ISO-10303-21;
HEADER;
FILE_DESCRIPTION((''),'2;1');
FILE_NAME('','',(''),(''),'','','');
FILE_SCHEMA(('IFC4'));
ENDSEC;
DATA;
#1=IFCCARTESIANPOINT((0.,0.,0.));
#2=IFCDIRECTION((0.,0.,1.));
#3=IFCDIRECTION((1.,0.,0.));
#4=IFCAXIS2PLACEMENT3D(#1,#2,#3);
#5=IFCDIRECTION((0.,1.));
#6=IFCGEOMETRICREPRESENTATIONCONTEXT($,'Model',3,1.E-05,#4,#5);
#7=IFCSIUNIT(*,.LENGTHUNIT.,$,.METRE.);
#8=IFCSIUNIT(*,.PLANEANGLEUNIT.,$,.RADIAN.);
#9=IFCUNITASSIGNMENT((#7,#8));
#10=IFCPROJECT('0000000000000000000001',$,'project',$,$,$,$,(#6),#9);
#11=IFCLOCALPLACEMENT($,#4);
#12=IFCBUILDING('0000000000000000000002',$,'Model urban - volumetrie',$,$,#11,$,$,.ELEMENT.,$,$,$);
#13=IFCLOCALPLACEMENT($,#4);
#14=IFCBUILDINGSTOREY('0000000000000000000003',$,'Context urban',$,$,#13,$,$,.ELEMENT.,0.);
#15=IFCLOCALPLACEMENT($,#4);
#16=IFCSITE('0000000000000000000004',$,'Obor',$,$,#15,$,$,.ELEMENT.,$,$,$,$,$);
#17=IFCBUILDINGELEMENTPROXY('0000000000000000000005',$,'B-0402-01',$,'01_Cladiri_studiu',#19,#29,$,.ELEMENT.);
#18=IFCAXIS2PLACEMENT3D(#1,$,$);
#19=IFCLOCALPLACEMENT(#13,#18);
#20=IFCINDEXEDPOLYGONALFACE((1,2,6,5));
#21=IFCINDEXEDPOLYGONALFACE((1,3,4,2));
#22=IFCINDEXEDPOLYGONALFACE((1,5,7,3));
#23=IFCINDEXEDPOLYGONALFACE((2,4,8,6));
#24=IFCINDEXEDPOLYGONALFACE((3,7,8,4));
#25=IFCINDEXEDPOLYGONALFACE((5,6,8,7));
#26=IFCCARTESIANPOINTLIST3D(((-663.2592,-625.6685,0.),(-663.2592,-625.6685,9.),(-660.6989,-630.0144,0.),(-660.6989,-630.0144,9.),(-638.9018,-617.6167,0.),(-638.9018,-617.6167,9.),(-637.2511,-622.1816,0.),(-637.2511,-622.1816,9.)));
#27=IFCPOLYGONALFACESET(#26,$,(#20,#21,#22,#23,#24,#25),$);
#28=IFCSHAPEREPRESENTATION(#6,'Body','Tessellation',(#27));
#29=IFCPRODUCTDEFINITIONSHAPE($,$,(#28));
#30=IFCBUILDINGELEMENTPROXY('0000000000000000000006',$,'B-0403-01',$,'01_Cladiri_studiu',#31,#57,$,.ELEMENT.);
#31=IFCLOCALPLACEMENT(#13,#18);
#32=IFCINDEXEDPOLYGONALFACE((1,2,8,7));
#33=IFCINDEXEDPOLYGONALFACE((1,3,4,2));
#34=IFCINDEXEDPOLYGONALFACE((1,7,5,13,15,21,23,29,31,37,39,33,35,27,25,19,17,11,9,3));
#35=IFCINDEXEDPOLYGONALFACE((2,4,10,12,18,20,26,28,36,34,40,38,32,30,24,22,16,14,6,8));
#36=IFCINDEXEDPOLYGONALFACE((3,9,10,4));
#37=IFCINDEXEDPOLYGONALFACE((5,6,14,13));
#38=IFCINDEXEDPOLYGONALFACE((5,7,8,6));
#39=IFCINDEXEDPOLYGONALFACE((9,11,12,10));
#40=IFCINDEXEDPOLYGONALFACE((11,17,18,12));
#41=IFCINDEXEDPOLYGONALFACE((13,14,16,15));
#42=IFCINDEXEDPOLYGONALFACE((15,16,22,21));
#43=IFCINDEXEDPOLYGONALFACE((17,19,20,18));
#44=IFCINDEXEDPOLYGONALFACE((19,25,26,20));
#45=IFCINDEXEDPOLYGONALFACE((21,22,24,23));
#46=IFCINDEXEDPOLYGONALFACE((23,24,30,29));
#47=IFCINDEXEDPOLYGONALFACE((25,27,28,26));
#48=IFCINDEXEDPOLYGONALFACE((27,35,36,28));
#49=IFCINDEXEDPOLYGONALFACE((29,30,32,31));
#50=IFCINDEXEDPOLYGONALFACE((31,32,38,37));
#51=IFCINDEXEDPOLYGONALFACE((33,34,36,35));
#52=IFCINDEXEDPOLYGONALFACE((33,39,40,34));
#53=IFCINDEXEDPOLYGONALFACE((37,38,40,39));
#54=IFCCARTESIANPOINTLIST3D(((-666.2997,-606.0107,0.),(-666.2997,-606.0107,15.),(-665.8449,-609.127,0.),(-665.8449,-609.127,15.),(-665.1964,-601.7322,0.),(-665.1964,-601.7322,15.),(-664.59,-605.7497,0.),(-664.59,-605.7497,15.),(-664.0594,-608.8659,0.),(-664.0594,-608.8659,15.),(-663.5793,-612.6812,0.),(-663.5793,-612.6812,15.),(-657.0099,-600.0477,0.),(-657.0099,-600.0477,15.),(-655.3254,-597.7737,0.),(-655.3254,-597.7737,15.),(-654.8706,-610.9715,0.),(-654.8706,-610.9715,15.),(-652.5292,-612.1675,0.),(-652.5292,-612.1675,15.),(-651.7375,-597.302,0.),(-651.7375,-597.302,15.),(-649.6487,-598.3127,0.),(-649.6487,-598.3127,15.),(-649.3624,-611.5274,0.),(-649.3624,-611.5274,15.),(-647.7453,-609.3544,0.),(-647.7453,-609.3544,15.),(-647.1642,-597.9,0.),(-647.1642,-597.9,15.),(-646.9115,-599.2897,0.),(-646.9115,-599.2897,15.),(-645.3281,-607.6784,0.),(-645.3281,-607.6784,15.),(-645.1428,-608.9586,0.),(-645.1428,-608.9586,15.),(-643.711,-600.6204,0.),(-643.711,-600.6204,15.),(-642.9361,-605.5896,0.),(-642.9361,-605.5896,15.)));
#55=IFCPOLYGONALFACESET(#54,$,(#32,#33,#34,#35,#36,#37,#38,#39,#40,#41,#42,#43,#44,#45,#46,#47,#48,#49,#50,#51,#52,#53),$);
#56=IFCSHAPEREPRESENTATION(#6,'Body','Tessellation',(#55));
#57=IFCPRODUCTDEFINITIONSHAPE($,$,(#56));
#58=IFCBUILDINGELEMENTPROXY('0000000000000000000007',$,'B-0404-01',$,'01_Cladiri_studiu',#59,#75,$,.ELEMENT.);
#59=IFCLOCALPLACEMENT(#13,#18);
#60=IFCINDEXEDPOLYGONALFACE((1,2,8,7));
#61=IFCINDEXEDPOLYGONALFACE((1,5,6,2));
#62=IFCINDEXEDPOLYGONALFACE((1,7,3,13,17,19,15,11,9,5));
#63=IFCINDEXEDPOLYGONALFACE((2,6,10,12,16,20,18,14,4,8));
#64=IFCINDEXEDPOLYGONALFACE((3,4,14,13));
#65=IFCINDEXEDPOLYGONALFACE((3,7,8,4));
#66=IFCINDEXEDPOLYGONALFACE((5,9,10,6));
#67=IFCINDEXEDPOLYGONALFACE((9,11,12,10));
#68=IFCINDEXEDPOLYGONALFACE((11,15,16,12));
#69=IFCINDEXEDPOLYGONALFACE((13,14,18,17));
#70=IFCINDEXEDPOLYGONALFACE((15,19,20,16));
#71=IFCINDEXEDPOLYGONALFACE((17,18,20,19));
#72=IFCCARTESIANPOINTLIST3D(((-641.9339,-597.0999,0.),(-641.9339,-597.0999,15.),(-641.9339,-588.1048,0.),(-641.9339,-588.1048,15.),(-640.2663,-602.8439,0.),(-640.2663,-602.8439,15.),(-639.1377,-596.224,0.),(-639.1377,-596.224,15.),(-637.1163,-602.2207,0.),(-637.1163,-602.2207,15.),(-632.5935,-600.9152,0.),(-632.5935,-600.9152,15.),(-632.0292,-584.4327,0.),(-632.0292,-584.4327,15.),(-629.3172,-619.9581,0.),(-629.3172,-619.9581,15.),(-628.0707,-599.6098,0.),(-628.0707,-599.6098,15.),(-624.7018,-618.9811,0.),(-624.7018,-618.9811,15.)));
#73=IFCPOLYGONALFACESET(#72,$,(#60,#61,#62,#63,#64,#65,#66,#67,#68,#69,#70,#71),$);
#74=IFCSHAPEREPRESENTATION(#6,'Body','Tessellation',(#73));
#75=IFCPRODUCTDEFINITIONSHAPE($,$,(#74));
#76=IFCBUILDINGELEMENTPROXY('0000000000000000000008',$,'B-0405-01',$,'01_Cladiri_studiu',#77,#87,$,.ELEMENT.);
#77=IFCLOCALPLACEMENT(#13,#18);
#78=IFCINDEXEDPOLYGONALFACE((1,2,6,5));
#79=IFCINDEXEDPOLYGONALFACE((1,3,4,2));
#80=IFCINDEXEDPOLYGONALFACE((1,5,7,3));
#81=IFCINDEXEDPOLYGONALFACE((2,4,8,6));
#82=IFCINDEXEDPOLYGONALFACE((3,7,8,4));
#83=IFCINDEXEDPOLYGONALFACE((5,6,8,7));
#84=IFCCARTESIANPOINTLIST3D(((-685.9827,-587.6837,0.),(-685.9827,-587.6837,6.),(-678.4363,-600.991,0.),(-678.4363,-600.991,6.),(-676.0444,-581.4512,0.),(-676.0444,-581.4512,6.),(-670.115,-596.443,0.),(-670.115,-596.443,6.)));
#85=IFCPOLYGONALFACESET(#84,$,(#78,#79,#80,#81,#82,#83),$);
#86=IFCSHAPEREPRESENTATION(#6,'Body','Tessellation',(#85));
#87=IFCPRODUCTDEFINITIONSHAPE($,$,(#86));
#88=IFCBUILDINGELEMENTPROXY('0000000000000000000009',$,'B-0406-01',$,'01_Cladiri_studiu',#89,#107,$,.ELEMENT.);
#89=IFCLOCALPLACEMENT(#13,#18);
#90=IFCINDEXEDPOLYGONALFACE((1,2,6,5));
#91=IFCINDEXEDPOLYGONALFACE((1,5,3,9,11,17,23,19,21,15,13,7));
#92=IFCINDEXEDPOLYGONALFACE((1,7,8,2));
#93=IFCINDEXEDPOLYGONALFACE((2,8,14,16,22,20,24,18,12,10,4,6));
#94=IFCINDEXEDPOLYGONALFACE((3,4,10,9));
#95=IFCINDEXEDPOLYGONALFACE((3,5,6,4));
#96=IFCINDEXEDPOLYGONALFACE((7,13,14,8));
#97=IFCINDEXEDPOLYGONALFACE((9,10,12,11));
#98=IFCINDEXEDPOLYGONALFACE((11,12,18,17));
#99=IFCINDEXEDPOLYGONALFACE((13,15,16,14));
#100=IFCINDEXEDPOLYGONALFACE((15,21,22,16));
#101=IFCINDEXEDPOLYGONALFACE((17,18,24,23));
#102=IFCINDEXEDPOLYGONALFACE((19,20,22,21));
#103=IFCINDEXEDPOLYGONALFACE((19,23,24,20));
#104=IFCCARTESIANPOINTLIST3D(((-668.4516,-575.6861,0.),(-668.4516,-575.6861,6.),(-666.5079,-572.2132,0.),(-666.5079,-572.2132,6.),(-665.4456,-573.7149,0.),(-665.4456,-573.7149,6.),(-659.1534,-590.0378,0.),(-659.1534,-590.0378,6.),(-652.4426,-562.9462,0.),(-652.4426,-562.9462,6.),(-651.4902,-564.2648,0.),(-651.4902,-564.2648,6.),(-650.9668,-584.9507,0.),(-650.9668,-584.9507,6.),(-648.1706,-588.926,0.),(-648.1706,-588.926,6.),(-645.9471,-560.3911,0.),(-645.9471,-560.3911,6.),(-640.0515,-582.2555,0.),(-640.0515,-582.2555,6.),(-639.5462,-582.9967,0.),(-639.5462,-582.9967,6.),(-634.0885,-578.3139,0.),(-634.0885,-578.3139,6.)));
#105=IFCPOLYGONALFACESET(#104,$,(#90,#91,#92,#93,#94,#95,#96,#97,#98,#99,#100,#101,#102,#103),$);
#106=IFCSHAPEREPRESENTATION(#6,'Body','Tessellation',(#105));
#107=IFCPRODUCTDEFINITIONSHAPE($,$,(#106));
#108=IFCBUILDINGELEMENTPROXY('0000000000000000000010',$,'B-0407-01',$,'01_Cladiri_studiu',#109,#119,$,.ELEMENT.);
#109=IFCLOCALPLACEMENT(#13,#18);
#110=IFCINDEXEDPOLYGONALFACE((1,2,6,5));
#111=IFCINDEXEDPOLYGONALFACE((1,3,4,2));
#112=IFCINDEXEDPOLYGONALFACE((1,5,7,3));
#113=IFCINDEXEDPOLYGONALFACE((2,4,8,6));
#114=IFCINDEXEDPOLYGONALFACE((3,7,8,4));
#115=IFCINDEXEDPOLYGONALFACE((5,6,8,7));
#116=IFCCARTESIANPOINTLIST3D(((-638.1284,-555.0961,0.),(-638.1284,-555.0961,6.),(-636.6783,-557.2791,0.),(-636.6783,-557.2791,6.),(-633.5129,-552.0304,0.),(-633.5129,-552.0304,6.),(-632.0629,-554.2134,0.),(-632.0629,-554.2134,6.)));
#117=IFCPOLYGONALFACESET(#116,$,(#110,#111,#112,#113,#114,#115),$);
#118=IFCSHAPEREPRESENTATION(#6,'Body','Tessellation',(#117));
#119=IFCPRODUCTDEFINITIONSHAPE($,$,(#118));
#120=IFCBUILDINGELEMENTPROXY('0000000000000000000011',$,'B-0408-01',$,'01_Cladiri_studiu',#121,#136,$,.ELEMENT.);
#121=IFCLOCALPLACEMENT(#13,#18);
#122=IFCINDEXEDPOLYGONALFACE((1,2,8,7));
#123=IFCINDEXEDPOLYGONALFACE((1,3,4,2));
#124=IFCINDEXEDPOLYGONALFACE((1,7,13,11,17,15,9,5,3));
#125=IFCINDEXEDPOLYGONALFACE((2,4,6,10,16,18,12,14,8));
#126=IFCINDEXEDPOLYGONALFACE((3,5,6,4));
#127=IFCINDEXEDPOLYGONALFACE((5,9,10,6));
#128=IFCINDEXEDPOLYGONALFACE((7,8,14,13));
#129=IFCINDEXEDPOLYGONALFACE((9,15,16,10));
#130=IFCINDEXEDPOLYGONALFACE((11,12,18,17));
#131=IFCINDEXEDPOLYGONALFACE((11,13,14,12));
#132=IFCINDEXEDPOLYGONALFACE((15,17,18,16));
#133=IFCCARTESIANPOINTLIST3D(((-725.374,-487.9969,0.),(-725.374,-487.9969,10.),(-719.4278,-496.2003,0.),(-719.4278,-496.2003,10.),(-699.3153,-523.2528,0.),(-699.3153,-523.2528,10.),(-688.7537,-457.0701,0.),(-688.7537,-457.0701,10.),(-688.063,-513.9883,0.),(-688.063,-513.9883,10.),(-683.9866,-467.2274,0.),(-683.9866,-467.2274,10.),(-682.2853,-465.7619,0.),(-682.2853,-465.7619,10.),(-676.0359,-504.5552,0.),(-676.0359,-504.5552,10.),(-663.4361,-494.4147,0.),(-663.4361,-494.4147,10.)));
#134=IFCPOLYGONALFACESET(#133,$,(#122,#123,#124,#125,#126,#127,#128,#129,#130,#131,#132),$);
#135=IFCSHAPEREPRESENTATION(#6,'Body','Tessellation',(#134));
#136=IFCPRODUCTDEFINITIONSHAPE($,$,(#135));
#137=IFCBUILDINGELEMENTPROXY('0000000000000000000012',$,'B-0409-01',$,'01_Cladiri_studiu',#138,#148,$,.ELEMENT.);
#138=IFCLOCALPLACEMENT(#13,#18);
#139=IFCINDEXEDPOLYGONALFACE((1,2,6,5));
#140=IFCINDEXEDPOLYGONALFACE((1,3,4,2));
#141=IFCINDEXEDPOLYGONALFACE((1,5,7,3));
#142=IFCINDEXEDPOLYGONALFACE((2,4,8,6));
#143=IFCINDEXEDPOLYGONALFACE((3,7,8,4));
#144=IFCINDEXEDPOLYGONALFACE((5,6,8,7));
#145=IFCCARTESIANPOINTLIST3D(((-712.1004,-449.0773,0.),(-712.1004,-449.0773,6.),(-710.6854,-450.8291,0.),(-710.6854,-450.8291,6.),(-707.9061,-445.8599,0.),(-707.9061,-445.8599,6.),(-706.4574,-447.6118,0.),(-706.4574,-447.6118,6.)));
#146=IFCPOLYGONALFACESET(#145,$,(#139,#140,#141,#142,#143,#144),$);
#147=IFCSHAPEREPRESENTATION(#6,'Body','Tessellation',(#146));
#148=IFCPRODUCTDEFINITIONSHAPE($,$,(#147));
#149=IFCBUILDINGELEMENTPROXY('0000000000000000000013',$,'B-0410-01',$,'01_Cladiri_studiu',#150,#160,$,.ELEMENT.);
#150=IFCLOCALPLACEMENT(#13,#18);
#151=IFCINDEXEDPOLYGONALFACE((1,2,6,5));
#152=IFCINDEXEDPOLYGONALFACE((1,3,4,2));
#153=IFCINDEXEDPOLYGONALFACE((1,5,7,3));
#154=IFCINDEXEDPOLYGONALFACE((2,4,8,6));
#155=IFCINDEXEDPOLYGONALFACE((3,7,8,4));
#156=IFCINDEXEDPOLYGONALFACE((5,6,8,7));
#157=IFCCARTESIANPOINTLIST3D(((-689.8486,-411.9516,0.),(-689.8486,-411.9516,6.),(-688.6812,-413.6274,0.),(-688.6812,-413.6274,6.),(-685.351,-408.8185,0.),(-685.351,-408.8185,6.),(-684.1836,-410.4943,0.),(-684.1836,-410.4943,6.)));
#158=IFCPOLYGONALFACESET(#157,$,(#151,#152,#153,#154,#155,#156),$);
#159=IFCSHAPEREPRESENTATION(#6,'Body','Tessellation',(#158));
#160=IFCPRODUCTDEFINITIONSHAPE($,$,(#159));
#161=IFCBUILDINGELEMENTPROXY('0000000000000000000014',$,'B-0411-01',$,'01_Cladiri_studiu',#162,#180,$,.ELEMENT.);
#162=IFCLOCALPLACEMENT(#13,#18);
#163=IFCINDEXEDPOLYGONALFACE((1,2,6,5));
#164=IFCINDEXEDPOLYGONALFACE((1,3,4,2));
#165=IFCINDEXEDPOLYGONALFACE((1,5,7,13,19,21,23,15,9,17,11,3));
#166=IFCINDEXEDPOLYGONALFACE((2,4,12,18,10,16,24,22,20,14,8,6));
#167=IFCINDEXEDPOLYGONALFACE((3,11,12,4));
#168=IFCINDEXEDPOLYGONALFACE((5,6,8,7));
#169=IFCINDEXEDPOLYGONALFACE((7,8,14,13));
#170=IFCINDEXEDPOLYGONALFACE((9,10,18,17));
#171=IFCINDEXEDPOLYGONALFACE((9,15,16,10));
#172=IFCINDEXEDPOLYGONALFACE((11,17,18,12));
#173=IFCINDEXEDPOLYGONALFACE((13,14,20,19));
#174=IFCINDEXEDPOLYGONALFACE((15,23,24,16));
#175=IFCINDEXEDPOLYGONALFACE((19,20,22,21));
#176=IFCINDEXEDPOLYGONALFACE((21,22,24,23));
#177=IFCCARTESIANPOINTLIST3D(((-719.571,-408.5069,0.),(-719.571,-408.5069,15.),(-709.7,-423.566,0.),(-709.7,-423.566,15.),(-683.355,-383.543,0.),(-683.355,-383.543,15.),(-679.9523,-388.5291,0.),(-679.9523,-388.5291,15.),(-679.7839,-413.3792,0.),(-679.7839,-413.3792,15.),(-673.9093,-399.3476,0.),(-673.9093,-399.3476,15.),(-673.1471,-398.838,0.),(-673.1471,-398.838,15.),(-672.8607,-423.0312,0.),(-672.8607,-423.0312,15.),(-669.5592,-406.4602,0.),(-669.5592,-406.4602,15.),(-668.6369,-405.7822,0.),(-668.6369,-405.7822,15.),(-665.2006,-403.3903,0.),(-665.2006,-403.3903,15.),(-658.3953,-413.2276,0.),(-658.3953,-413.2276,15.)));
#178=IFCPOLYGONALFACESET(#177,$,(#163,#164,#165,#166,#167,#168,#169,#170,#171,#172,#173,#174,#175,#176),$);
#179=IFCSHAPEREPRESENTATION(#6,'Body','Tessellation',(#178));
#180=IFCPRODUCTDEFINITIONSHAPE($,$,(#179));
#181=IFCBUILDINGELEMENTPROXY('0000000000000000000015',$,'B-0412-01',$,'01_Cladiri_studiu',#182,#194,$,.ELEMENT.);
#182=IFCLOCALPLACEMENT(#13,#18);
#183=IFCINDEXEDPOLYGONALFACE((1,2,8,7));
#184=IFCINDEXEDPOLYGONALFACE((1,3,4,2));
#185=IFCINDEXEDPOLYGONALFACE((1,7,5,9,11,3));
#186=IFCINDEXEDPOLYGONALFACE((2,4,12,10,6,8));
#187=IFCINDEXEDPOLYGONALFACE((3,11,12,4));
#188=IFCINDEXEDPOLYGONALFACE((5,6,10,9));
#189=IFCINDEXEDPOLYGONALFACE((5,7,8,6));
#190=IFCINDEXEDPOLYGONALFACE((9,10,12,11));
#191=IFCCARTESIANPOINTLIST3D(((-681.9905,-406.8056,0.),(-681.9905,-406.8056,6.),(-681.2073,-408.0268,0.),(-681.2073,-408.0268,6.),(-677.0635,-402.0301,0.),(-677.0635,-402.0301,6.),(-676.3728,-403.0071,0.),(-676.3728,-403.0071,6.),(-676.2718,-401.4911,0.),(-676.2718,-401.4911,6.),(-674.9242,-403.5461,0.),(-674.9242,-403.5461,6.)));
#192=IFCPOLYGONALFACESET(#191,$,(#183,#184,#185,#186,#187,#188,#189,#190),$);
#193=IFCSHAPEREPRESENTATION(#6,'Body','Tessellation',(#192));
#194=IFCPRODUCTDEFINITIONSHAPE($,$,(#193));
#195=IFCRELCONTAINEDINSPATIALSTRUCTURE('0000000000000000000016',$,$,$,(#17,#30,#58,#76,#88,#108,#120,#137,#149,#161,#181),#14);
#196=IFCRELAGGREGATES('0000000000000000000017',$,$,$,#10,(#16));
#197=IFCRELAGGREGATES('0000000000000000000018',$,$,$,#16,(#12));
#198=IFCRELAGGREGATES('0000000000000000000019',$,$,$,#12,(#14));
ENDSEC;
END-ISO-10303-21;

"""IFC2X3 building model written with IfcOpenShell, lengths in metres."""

from ifc_helpers import new_model, si_unit, direction, origin_with_axes, place, context, project, spatial, polyline, outline, extrude, element, save


model = new_model("IFC2X3")

# Units and contexts
model_context = context("Model", 3, precision=1e-05, world=origin_with_axes(), true_north=direction((0.0, 1.0)))
ifc_project = project(units=[si_unit("LENGTHUNIT", "METRE"), si_unit("PLANEANGLEUNIT", "RADIAN")], contexts=[model_context])

# Site, building, storey
site_placement = place(None, origin_with_axes())
site = spatial("IfcSite", under=ifc_project, at=site_placement, Name="Obor", CompositionType="ELEMENT")
building_placement = place(None, origin_with_axes())
building = spatial("IfcBuilding", under=site, at=building_placement, Name="Model urban - volumetrie", CompositionType="ELEMENT")
storey_placement = place(None, origin_with_axes())
storey = spatial("IfcBuildingStorey", under=building, at=storey_placement, Name="Context urban", CompositionType="ELEMENT", Elevation=0.0)

# Building element proxies
proxy_1_placement = place(None, origin_with_axes())
element("IfcBuildingElementProxy", 1, at=proxy_1_placement, inside=storey, Name="B-0402-01", ObjectType="01_Cladiri_studiu", CompositionType="ELEMENT", context=model_context, shape_type="SweptSolid", body=[
    extrude(outline(polyline([(-638.9018, -617.6167), (-663.2592, -625.6685), (-660.6989, -630.0144), (-637.2511, -622.1816), (-638.9018, -617.6167)])), origin_with_axes(), (0.0, 0.0, 1.0), 9.0),
])
proxy_2_placement = place(None, origin_with_axes())
element("IfcBuildingElementProxy", 2, at=proxy_2_placement, inside=storey, Name="B-0403-01", ObjectType="01_Cladiri_studiu", CompositionType="ELEMENT", context=model_context, shape_type="SweptSolid", body=[
    extrude(outline(polyline([(-663.5793, -612.6812), (-654.8706, -610.9715), (-652.5292, -612.1675), (-649.3624, -611.5274), (-647.7453, -609.3544), (-645.1428, -608.9586), (-645.3281, -607.6784), (-642.9361, -605.5896), (-643.711, -600.6204), (-646.9115, -599.2897), (-647.1642, -597.9), (-649.6487, -598.3127), (-651.7375, -597.302), (-655.3254, -597.7737), (-657.0099, -600.0477), (-665.1964, -601.7322), (-664.59, -605.7497), (-666.2997, -606.0107), (-665.8449, -609.127), (-664.0594, -608.8659), (-663.5793, -612.6812)])), origin_with_axes(), (0.0, 0.0, 1.0), 15.0),
])
proxy_3_placement = place(None, origin_with_axes())
element("IfcBuildingElementProxy", 3, at=proxy_3_placement, inside=storey, Name="B-0404-01", ObjectType="01_Cladiri_studiu", CompositionType="ELEMENT", context=model_context, shape_type="SweptSolid", body=[
    extrude(outline(polyline([(-632.0292, -584.4327), (-641.9339, -588.1048), (-639.1377, -596.224), (-641.9339, -597.0999), (-640.2663, -602.8439), (-637.1163, -602.2207), (-632.5935, -600.9152), (-629.3172, -619.9581), (-624.7018, -618.9811), (-628.0707, -599.6098), (-632.0292, -584.4327)])), origin_with_axes(), (0.0, 0.0, 1.0), 15.0),
])
proxy_4_placement = place(None, origin_with_axes())
element("IfcBuildingElementProxy", 4, at=proxy_4_placement, inside=storey, Name="B-0405-01", ObjectType="01_Cladiri_studiu", CompositionType="ELEMENT", context=model_context, shape_type="SweptSolid", body=[
    extrude(outline(polyline([(-678.4363, -600.991), (-670.115, -596.443), (-676.0444, -581.4512), (-685.9827, -587.6837), (-678.4363, -600.991)])), origin_with_axes(), (0.0, 0.0, 1.0), 6.0),
])
proxy_5_placement = place(None, origin_with_axes())
element("IfcBuildingElementProxy", 5, at=proxy_5_placement, inside=storey, Name="B-0406-01", ObjectType="01_Cladiri_studiu", CompositionType="ELEMENT", context=model_context, shape_type="SweptSolid", body=[
    extrude(outline(polyline([(-666.5079, -572.2132), (-665.4456, -573.7149), (-668.4516, -575.6861), (-659.1534, -590.0378), (-650.9668, -584.9507), (-648.1706, -588.926), (-639.5462, -582.9967), (-640.0515, -582.2555), (-634.0885, -578.3139), (-645.9471, -560.3911), (-651.4902, -564.2648), (-652.4426, -562.9462), (-666.5079, -572.2132)])), origin_with_axes(), (0.0, 0.0, 1.0), 6.0),
])
proxy_6_placement = place(None, origin_with_axes())
element("IfcBuildingElementProxy", 6, at=proxy_6_placement, inside=storey, Name="B-0407-01", ObjectType="01_Cladiri_studiu", CompositionType="ELEMENT", context=model_context, shape_type="SweptSolid", body=[
    extrude(outline(polyline([(-632.0629, -554.2134), (-633.5129, -552.0304), (-638.1284, -555.0961), (-636.6783, -557.2791), (-632.0629, -554.2134)])), origin_with_axes(), (0.0, 0.0, 1.0), 6.0),
])
proxy_7_placement = place(None, origin_with_axes())
element("IfcBuildingElementProxy", 7, at=proxy_7_placement, inside=storey, Name="B-0408-01", ObjectType="01_Cladiri_studiu", CompositionType="ELEMENT", context=model_context, shape_type="SweptSolid", body=[
    extrude(outline(polyline([(-688.7537, -457.0701), (-725.374, -487.9969), (-719.4278, -496.2003), (-699.3153, -523.2528), (-688.063, -513.9883), (-676.0359, -504.5552), (-663.4361, -494.4147), (-683.9866, -467.2274), (-682.2853, -465.7619), (-688.7537, -457.0701)])), origin_with_axes(), (0.0, 0.0, 1.0), 10.0),
])
proxy_8_placement = place(None, origin_with_axes())
element("IfcBuildingElementProxy", 8, at=proxy_8_placement, inside=storey, Name="B-0409-01", ObjectType="01_Cladiri_studiu", CompositionType="ELEMENT", context=model_context, shape_type="SweptSolid", body=[
    extrude(outline(polyline([(-706.4574, -447.6118), (-707.9061, -445.8599), (-712.1004, -449.0773), (-710.6854, -450.8291), (-706.4574, -447.6118)])), origin_with_axes(), (0.0, 0.0, 1.0), 6.0),
])
proxy_9_placement = place(None, origin_with_axes())
element("IfcBuildingElementProxy", 9, at=proxy_9_placement, inside=storey, Name="B-0410-01", ObjectType="01_Cladiri_studiu", CompositionType="ELEMENT", context=model_context, shape_type="SweptSolid", body=[
    extrude(outline(polyline([(-684.1836, -410.4943), (-685.351, -408.8185), (-689.8486, -411.9516), (-688.6812, -413.6274), (-684.1836, -410.4943)])), origin_with_axes(), (0.0, 0.0, 1.0), 6.0),
])
proxy_10_placement = place(None, origin_with_axes())
element("IfcBuildingElementProxy", 10, at=proxy_10_placement, inside=storey, Name="B-0411-01", ObjectType="01_Cladiri_studiu", CompositionType="ELEMENT", context=model_context, shape_type="SweptSolid", body=[
    extrude(outline(polyline([(-668.6369, -405.7822), (-673.1471, -398.838), (-679.9523, -388.5291), (-683.355, -383.543), (-719.571, -408.5069), (-709.7, -423.566), (-673.9093, -399.3476), (-669.5592, -406.4602), (-679.7839, -413.3792), (-672.8607, -423.0312), (-658.3953, -413.2276), (-665.2006, -403.3903), (-668.6369, -405.7822)])), origin_with_axes(), (0.0, 0.0, 1.0), 15.0),
])
proxy_11_placement = place(None, origin_with_axes())
element("IfcBuildingElementProxy", 11, at=proxy_11_placement, inside=storey, Name="B-0412-01", ObjectType="01_Cladiri_studiu", CompositionType="ELEMENT", context=model_context, shape_type="SweptSolid", body=[
    extrude(outline(polyline([(-681.2073, -408.0268), (-674.9242, -403.5461), (-676.2718, -401.4911), (-677.0635, -402.0301), (-676.3728, -403.0071), (-681.9905, -406.8056), (-681.2073, -408.0268)])), origin_with_axes(), (0.0, 0.0, 1.0), 6.0),
])

save(model, "model.ifc")
